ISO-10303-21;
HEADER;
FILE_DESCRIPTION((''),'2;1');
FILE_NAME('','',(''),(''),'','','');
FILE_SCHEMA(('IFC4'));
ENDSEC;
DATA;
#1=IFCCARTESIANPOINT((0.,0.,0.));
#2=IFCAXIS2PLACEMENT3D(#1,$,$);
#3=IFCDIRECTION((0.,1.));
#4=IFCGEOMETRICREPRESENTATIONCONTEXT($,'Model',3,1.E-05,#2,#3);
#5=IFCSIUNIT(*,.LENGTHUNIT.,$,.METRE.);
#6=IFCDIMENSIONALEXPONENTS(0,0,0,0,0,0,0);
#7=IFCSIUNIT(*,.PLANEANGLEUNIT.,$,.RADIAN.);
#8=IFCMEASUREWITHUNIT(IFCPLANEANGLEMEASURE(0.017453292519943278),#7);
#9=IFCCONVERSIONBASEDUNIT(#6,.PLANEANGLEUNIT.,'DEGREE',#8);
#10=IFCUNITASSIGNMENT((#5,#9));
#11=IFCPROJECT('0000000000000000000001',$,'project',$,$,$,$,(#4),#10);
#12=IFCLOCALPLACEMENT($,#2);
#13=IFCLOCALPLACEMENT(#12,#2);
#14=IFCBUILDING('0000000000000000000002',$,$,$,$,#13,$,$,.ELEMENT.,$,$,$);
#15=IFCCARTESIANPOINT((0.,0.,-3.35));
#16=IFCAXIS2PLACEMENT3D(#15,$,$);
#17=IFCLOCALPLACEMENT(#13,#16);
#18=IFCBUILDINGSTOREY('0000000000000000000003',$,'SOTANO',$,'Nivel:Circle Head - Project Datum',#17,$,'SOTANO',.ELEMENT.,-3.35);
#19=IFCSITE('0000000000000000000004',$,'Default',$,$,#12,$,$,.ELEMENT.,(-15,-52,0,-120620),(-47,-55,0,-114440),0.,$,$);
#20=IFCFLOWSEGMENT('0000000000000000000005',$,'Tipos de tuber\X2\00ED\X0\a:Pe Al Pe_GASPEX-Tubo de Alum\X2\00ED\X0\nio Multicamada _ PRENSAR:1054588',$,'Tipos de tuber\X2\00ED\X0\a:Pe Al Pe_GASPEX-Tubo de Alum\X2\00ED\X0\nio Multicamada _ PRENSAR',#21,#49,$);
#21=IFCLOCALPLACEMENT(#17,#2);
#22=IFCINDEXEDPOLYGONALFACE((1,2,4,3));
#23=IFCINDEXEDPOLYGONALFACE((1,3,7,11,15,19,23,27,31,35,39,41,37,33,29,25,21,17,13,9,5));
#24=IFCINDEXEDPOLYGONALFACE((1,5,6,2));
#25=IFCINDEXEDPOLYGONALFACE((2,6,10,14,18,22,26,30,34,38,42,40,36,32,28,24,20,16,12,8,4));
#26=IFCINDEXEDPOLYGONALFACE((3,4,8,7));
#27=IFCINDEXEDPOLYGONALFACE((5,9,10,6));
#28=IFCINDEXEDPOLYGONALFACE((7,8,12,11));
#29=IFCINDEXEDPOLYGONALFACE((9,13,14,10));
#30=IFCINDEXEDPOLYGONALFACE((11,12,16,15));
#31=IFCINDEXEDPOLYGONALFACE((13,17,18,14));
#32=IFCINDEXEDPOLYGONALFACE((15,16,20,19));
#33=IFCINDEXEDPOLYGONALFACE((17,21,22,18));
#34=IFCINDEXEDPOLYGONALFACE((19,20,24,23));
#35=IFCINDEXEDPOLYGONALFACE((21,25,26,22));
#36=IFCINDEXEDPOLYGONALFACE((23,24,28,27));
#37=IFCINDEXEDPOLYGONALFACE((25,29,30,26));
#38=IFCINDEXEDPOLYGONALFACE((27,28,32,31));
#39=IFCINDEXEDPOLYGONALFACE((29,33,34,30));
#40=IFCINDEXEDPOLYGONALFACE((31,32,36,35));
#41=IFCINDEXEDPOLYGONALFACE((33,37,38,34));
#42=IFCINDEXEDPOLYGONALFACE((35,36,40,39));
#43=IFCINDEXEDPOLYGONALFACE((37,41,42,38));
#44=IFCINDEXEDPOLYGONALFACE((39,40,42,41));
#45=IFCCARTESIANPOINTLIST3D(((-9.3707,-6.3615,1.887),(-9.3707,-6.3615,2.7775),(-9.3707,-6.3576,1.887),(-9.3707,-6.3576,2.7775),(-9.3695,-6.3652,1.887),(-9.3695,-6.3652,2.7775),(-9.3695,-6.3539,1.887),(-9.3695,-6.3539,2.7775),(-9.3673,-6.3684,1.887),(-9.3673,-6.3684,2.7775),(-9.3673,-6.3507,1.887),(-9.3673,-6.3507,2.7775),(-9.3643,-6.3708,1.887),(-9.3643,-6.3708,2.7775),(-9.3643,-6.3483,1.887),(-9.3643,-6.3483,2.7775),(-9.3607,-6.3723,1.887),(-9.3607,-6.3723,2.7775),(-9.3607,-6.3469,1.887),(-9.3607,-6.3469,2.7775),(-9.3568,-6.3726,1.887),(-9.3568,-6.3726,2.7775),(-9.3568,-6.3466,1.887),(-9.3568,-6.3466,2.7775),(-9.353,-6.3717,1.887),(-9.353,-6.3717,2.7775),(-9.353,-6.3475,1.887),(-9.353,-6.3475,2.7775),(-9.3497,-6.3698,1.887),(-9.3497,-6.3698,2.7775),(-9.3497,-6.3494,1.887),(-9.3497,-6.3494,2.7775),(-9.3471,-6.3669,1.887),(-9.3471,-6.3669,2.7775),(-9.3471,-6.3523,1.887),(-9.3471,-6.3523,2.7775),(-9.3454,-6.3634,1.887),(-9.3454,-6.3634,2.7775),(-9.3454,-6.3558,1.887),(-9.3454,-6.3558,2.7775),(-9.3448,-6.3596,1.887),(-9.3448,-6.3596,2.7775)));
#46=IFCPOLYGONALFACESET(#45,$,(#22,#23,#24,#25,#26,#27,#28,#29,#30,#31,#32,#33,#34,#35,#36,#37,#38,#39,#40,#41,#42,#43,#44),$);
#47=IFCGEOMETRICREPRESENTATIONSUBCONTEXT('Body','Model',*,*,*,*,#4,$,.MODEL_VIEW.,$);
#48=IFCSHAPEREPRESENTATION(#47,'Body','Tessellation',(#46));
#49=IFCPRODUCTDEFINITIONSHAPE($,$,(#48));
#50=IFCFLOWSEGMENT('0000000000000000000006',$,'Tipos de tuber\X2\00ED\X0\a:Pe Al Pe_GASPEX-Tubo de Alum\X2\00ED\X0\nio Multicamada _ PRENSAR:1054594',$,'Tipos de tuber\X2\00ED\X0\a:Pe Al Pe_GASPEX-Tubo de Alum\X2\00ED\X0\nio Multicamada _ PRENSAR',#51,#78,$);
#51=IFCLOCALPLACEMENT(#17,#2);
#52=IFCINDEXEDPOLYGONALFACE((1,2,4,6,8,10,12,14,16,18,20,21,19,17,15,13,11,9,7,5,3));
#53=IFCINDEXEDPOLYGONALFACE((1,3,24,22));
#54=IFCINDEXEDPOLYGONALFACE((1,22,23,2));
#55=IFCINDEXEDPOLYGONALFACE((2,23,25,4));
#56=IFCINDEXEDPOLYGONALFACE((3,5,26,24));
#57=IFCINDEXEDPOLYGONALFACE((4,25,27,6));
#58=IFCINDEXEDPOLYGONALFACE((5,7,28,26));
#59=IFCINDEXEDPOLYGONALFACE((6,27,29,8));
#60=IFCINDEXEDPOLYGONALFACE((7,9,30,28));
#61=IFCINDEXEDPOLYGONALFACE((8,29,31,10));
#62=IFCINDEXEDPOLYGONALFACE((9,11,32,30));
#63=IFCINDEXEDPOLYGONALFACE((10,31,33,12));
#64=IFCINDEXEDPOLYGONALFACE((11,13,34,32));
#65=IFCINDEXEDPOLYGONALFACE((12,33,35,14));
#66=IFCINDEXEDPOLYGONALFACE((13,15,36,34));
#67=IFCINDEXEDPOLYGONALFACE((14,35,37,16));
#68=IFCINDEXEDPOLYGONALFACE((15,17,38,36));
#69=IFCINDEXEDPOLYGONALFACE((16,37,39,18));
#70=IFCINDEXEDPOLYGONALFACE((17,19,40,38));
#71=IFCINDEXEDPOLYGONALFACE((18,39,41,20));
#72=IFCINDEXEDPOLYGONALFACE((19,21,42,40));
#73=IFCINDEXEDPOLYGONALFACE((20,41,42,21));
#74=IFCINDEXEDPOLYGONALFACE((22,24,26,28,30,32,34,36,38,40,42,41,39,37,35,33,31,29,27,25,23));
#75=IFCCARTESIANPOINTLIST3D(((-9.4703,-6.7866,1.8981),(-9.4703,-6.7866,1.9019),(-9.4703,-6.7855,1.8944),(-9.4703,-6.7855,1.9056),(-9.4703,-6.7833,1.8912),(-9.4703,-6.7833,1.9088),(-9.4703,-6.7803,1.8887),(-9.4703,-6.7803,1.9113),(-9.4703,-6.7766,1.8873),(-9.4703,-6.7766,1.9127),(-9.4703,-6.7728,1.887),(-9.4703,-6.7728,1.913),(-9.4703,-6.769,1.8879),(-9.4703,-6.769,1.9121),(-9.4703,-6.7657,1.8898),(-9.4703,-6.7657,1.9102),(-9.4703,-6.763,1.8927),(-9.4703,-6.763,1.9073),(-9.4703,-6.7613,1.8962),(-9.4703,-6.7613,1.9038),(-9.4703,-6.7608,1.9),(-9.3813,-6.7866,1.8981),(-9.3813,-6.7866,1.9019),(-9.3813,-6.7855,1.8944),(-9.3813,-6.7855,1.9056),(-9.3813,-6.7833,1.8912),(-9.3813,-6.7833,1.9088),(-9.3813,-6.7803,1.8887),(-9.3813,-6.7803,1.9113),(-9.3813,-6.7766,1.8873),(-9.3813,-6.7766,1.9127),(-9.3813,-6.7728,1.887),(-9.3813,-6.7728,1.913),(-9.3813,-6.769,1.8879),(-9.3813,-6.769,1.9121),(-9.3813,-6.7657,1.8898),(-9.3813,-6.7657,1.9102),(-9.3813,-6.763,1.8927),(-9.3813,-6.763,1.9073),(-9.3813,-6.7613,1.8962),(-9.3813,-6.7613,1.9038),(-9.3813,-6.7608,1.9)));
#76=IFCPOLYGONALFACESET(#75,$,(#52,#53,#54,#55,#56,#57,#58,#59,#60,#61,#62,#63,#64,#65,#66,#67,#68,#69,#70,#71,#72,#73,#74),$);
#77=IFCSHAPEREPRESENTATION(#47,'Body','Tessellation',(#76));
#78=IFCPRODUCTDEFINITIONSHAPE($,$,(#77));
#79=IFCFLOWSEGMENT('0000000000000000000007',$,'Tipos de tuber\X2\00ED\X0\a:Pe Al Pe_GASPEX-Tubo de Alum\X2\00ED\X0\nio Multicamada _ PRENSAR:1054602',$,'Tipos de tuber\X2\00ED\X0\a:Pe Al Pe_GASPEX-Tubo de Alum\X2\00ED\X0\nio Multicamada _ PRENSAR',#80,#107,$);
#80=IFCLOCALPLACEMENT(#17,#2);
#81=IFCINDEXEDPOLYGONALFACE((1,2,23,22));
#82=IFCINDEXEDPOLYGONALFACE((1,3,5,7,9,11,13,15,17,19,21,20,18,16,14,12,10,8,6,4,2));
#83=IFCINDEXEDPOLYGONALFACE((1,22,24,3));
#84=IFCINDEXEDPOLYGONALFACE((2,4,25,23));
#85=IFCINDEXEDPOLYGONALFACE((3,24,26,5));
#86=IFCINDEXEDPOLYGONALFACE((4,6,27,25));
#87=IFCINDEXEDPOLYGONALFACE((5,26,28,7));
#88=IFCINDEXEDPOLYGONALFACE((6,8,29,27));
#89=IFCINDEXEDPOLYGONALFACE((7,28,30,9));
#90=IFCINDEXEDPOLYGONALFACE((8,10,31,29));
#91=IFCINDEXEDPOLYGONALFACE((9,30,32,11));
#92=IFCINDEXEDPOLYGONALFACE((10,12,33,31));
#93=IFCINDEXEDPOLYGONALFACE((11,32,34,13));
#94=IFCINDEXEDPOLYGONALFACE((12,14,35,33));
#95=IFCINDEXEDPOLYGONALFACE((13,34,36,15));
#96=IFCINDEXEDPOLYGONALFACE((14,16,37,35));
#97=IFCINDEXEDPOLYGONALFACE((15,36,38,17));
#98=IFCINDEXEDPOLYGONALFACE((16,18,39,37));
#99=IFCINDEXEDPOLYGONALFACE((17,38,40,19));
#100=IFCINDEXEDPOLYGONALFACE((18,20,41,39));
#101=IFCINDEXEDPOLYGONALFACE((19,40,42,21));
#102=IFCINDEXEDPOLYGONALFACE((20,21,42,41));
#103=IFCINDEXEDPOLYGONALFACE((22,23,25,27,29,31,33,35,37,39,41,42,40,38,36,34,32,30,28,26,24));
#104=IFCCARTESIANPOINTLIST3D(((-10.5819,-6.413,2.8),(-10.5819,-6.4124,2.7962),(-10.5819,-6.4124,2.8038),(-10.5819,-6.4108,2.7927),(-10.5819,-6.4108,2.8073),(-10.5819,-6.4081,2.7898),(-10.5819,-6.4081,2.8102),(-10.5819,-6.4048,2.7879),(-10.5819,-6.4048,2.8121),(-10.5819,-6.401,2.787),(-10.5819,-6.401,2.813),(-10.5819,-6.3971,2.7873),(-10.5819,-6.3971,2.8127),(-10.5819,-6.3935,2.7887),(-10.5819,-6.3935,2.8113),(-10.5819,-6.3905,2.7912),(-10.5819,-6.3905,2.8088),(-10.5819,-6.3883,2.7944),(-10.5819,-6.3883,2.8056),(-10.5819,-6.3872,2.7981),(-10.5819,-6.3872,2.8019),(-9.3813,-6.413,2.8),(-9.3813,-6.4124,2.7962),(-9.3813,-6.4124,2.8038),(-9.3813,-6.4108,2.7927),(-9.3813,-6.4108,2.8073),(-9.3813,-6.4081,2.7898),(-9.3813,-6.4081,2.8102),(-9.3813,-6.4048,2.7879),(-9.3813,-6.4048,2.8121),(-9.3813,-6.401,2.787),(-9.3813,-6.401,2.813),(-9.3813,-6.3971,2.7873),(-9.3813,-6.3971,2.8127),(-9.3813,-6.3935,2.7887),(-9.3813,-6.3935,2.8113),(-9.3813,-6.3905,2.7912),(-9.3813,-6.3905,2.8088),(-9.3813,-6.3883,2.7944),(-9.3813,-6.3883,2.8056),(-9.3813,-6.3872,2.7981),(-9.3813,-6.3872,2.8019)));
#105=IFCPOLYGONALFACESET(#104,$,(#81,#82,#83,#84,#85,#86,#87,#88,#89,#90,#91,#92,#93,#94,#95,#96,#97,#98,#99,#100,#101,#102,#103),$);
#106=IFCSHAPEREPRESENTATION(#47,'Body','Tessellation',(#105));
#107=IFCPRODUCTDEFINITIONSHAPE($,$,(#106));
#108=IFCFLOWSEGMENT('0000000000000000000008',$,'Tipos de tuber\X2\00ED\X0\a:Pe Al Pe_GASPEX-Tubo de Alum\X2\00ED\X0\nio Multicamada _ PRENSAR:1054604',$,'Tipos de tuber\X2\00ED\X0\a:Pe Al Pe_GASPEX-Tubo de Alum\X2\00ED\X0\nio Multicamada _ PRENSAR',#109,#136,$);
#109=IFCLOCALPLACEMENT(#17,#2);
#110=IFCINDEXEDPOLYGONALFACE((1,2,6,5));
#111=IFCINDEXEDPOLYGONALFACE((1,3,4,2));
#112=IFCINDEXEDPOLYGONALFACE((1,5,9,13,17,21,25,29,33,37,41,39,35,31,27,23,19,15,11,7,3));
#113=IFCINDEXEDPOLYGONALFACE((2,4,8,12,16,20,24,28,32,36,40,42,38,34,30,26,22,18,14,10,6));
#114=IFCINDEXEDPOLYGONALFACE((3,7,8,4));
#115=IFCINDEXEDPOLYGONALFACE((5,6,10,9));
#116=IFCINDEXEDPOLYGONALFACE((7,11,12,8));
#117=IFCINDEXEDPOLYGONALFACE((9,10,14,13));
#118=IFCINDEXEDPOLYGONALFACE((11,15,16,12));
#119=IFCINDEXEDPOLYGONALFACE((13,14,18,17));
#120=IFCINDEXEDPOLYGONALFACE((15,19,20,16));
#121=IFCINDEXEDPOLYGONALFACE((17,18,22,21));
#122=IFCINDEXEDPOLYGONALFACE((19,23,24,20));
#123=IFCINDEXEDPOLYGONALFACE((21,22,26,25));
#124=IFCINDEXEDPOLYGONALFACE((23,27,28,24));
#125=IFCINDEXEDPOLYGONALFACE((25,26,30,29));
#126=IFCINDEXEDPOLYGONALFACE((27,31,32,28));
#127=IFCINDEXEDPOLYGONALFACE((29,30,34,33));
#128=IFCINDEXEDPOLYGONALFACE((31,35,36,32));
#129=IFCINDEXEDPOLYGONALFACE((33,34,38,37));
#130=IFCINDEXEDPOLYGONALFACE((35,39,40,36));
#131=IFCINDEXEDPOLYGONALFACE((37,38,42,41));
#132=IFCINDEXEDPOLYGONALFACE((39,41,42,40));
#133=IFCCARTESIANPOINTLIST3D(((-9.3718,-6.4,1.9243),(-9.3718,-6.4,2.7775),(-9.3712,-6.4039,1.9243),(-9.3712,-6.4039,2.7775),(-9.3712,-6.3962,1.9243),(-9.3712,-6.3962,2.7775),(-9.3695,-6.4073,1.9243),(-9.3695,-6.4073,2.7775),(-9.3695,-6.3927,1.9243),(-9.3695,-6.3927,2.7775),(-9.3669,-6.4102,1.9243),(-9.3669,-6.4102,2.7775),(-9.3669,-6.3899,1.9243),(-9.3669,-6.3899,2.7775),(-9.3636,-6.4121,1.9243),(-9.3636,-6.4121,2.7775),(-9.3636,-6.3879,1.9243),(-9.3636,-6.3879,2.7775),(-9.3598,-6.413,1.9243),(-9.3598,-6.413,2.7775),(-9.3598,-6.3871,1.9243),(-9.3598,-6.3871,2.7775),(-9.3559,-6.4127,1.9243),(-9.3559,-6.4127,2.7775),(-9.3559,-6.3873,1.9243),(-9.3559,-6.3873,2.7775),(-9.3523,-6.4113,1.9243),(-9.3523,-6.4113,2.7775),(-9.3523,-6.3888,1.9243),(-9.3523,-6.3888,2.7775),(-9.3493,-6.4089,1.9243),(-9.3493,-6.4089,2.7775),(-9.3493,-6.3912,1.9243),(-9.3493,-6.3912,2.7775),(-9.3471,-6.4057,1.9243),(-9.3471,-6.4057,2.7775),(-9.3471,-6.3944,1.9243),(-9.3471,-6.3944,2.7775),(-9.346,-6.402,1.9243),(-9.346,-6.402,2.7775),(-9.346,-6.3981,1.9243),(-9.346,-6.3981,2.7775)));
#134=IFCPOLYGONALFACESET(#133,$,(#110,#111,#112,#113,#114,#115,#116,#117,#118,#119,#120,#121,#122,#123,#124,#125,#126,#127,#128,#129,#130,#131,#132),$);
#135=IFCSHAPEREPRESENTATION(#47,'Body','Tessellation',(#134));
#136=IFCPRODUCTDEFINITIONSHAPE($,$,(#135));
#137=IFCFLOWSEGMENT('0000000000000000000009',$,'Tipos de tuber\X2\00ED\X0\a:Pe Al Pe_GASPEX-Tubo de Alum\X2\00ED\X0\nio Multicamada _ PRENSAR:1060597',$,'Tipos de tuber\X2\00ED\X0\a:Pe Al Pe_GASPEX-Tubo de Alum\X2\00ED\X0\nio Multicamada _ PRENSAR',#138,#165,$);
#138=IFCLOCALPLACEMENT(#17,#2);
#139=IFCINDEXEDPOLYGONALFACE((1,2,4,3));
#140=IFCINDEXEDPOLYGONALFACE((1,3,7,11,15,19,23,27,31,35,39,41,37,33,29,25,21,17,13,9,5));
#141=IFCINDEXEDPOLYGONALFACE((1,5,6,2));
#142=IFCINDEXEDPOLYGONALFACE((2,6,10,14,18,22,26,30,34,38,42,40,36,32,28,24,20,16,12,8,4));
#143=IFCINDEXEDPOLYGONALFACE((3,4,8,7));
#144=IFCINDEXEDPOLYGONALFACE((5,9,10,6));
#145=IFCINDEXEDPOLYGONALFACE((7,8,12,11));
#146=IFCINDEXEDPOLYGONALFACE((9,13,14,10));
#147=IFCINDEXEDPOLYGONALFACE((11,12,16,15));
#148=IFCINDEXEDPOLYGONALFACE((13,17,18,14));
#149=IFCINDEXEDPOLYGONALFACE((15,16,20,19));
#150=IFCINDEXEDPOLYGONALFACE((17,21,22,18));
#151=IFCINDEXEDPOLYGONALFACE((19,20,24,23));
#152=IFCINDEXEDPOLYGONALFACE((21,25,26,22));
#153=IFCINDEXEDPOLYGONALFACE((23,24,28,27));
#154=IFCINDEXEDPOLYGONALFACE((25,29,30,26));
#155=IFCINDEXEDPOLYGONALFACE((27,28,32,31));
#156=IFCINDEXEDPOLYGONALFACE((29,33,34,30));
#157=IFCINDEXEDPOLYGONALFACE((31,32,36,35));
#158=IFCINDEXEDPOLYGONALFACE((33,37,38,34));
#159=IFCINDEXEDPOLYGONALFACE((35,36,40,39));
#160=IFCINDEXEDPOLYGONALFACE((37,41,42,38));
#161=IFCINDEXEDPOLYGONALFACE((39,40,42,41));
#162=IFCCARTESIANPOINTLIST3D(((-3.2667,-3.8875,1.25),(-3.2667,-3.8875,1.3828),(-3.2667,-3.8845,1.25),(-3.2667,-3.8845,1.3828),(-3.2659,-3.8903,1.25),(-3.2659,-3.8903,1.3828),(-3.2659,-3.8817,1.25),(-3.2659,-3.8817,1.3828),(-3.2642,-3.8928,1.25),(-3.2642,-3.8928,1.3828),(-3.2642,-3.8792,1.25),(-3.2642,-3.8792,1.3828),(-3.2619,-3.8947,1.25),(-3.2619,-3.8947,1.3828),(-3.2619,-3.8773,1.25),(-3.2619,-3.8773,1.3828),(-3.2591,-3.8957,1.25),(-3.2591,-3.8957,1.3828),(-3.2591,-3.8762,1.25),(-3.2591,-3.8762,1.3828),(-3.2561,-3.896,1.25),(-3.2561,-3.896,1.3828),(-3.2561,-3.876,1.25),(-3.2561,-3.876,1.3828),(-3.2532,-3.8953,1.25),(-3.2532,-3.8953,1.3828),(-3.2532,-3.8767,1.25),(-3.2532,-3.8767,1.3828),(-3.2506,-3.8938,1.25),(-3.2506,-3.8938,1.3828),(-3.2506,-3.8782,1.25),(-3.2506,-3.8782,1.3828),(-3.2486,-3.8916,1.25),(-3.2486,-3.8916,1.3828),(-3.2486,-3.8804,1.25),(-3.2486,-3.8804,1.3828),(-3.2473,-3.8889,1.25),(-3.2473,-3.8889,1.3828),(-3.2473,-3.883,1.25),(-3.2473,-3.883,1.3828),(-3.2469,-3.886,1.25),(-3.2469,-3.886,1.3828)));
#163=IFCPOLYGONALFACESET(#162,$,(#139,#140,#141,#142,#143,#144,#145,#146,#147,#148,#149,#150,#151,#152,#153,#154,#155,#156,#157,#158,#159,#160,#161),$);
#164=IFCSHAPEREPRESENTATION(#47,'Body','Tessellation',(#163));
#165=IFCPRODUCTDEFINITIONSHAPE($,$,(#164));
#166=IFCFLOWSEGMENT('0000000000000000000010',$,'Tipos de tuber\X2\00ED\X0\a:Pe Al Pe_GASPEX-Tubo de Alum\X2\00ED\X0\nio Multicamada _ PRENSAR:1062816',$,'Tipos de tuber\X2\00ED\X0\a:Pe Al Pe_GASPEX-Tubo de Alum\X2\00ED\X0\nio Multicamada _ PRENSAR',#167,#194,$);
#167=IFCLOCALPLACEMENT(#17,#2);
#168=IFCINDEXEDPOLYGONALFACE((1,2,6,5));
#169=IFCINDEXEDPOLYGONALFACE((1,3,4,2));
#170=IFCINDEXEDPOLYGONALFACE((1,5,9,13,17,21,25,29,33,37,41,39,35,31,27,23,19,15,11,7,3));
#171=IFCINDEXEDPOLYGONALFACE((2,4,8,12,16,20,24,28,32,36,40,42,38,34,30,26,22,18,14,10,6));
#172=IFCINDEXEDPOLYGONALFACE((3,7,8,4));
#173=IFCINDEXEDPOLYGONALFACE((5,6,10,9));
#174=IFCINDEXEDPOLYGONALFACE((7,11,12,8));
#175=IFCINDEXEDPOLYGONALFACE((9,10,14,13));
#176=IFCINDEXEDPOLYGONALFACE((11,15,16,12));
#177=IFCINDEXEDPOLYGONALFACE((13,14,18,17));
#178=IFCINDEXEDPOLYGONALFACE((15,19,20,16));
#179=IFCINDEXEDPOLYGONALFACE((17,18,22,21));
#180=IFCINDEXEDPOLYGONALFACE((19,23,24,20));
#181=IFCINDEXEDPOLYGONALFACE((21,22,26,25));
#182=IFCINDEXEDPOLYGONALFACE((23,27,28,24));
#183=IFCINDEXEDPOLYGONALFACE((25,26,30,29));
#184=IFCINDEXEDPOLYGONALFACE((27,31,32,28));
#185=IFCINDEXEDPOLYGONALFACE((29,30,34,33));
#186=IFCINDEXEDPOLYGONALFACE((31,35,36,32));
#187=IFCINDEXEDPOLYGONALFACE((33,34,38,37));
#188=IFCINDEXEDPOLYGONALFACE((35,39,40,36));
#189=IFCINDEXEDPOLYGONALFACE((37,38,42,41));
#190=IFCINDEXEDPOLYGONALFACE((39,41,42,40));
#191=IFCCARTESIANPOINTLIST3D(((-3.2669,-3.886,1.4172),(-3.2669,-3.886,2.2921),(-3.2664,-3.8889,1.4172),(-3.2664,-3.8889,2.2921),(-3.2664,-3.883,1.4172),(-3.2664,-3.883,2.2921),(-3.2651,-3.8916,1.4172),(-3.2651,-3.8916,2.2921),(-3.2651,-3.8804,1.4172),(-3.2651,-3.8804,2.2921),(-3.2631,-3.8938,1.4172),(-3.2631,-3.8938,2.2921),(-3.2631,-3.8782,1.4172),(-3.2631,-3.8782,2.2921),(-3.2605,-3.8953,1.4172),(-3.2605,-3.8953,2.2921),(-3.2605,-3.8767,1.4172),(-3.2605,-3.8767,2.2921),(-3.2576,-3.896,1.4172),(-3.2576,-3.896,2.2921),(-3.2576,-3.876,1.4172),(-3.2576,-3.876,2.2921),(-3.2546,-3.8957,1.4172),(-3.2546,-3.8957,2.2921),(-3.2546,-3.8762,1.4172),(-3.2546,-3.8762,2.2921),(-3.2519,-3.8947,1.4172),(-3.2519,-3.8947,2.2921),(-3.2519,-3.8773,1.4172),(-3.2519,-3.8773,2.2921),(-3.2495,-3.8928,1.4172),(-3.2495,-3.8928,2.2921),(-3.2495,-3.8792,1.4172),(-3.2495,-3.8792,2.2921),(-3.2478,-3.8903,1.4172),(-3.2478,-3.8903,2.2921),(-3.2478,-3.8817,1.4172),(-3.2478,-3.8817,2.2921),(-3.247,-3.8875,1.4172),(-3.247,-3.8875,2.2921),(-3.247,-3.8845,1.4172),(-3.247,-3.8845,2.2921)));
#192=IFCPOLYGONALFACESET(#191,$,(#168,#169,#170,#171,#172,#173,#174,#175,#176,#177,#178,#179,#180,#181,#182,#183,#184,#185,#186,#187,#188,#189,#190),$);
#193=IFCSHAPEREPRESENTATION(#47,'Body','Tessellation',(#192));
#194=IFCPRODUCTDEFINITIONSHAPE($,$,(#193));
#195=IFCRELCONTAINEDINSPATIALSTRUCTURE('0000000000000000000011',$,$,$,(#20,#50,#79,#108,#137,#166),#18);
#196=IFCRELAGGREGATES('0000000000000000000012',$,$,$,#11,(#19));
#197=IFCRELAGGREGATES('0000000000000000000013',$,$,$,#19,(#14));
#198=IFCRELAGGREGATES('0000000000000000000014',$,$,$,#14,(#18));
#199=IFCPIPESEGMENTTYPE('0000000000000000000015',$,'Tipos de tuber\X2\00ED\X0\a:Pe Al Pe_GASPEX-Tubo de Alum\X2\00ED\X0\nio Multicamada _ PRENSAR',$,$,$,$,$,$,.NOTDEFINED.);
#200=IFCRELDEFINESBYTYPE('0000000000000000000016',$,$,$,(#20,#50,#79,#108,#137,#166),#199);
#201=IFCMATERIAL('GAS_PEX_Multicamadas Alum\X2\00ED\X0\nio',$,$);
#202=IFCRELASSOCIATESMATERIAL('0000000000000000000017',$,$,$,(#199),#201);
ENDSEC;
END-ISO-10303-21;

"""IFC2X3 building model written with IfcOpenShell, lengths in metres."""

from ifc_helpers import new_model, entity, si_unit, converted_unit, direction, frame, frame_2d, origin, origin_2d_with_axis, place, context, subcontext, project, spatial, circle, extrude, material, type_object, element, save


model = new_model("IFC2X3")

# Units and contexts
model_context = context("Model", 3, precision=1e-05, world=origin(), true_north=direction((0.0, 1.0)))
body_context = subcontext(model_context, "Body", "Model", "MODEL_VIEW")
ifc_project = project(units=[si_unit("LENGTHUNIT", "METRE"), converted_unit("PLANEANGLEUNIT", "DEGREE", entity("IfcPlaneAngleMeasure", 0.017453292519943278), si_unit("PLANEANGLEUNIT", "RADIAN"), dimensions=[0, 0, 0, 0, 0, 0, 0])], contexts=[model_context])

# Site, building, storey
site_placement = place(None, origin())
site = spatial("IfcSite", under=ifc_project, at=site_placement, Name="Default", CompositionType="ELEMENT", RefLatitude=(-15, -52, 0, -120620), RefLongitude=(-47, -55, 0, -114440), RefElevation=0.0)
building_placement = place(site_placement, origin())
building = spatial("IfcBuilding", under=site, at=building_placement, CompositionType="ELEMENT")
storey_placement = place(building_placement, frame((0.0, 0.0, -3.35)))
storey = spatial("IfcBuildingStorey", under=building, at=storey_placement, Name="SOTANO", ObjectType="Nivel:Circle Head - Project Datum", LongName="SOTANO", CompositionType="ELEMENT", Elevation=-3.35)

# Flow segments
ifc_material = material(Name="GAS_PEX_Multicamadas Alumínio")
pipe_segment_type_1 = type_object("IfcPipeSegmentType", Name="Tipos de tubería:Pe Al Pe_GASPEX-Tubo de Alumínio Multicamada _ PRENSAR", PredefinedType="NOTDEFINED", material=ifc_material)
flow_segment_1_placement = place(storey_placement, origin())
element("IfcFlowSegment", 1, at=flow_segment_1_placement, inside=storey, type_object=pipe_segment_type_1, Name="Tipos de tubería:Pe Al Pe_GASPEX-Tubo de Alumínio Multicamada _ PRENSAR:1054588", ObjectType="Tipos de tubería:Pe Al Pe_GASPEX-Tubo de Alumínio Multicamada _ PRENSAR", context=body_context, shape_type="SweptSolid", body=[
    extrude(circle(Radius=0.013, at=frame_2d((0.0, 0.0), x_axis=(1.0, 0.0))), frame((-9.3578, -6.3596, 1.887)), (0.0, 0.0, 1.0), 0.8905),
])
flow_segment_2_placement = place(storey_placement, origin())
element("IfcFlowSegment", 2, at=flow_segment_2_placement, inside=storey, type_object=pipe_segment_type_1, Name="Tipos de tubería:Pe Al Pe_GASPEX-Tubo de Alumínio Multicamada _ PRENSAR:1054594", ObjectType="Tipos de tubería:Pe Al Pe_GASPEX-Tubo de Alumínio Multicamada _ PRENSAR", context=body_context, shape_type="SweptSolid", body=[
    extrude(circle(Radius=0.013, at=frame_2d((0.0, 0.0), x_axis=(1.0, 0.0))), frame((-9.4703, -6.7738, 1.9), z_axis=(1.0, 0.0, 0.0), x_axis=(0.0, 1.0, 0.0)), (0.0, 0.0, 1.0), 0.089),
])
flow_segment_3_placement = place(storey_placement, origin())
element("IfcFlowSegment", 3, at=flow_segment_3_placement, inside=storey, type_object=pipe_segment_type_1, Name="Tipos de tubería:Pe Al Pe_GASPEX-Tubo de Alumínio Multicamada _ PRENSAR:1054602", ObjectType="Tipos de tubería:Pe Al Pe_GASPEX-Tubo de Alumínio Multicamada _ PRENSAR", context=body_context, shape_type="SweptSolid", body=[
    extrude(circle(Radius=0.013, at=origin_2d_with_axis()), frame((-10.5819, -6.4, 2.8), z_axis=(1.0, 0.0, 0.0), x_axis=(0.0, -1.0, 0.0)), (0.0, 0.0, 1.0), 1.2006),
])
flow_segment_4_placement = place(storey_placement, origin())
element("IfcFlowSegment", 4, at=flow_segment_4_placement, inside=storey, type_object=pipe_segment_type_1, Name="Tipos de tubería:Pe Al Pe_GASPEX-Tubo de Alumínio Multicamada _ PRENSAR:1054604", ObjectType="Tipos de tubería:Pe Al Pe_GASPEX-Tubo de Alumínio Multicamada _ PRENSAR", context=body_context, shape_type="SweptSolid", body=[
    extrude(circle(Radius=0.013, at=origin_2d_with_axis()), frame((-9.3588, -6.4, 1.9243), z_axis=(0.0, 0.0, 1.0), x_axis=(-1.0, 0.0, 0.0)), (0.0, 0.0, 1.0), 0.8532),
])
flow_segment_5_placement = place(storey_placement, origin())
element("IfcFlowSegment", 5, at=flow_segment_5_placement, inside=storey, type_object=pipe_segment_type_1, Name="Tipos de tubería:Pe Al Pe_GASPEX-Tubo de Alumínio Multicamada _ PRENSAR:1060597", ObjectType="Tipos de tubería:Pe Al Pe_GASPEX-Tubo de Alumínio Multicamada _ PRENSAR", context=body_context, shape_type="SweptSolid", body=[
    extrude(circle(Radius=0.01, at=origin_2d_with_axis()), frame((-3.2569, -3.886, 1.25)), (0.0, 0.0, 1.0), 0.1328),
])
flow_segment_6_placement = place(storey_placement, origin())
element("IfcFlowSegment", 6, at=flow_segment_6_placement, inside=storey, type_object=pipe_segment_type_1, Name="Tipos de tubería:Pe Al Pe_GASPEX-Tubo de Alumínio Multicamada _ PRENSAR:1062816", ObjectType="Tipos de tubería:Pe Al Pe_GASPEX-Tubo de Alumínio Multicamada _ PRENSAR", context=body_context, shape_type="SweptSolid", body=[
    extrude(circle(Radius=0.01, at=origin_2d_with_axis()), frame((-3.2569, -3.886, 1.4171), z_axis=(0.0, 0.0, 1.0), x_axis=(-1.0, 0.0, 0.0)), (0.0, 0.0, 1.0), 0.875),
])

save(model, "model.ifc")
